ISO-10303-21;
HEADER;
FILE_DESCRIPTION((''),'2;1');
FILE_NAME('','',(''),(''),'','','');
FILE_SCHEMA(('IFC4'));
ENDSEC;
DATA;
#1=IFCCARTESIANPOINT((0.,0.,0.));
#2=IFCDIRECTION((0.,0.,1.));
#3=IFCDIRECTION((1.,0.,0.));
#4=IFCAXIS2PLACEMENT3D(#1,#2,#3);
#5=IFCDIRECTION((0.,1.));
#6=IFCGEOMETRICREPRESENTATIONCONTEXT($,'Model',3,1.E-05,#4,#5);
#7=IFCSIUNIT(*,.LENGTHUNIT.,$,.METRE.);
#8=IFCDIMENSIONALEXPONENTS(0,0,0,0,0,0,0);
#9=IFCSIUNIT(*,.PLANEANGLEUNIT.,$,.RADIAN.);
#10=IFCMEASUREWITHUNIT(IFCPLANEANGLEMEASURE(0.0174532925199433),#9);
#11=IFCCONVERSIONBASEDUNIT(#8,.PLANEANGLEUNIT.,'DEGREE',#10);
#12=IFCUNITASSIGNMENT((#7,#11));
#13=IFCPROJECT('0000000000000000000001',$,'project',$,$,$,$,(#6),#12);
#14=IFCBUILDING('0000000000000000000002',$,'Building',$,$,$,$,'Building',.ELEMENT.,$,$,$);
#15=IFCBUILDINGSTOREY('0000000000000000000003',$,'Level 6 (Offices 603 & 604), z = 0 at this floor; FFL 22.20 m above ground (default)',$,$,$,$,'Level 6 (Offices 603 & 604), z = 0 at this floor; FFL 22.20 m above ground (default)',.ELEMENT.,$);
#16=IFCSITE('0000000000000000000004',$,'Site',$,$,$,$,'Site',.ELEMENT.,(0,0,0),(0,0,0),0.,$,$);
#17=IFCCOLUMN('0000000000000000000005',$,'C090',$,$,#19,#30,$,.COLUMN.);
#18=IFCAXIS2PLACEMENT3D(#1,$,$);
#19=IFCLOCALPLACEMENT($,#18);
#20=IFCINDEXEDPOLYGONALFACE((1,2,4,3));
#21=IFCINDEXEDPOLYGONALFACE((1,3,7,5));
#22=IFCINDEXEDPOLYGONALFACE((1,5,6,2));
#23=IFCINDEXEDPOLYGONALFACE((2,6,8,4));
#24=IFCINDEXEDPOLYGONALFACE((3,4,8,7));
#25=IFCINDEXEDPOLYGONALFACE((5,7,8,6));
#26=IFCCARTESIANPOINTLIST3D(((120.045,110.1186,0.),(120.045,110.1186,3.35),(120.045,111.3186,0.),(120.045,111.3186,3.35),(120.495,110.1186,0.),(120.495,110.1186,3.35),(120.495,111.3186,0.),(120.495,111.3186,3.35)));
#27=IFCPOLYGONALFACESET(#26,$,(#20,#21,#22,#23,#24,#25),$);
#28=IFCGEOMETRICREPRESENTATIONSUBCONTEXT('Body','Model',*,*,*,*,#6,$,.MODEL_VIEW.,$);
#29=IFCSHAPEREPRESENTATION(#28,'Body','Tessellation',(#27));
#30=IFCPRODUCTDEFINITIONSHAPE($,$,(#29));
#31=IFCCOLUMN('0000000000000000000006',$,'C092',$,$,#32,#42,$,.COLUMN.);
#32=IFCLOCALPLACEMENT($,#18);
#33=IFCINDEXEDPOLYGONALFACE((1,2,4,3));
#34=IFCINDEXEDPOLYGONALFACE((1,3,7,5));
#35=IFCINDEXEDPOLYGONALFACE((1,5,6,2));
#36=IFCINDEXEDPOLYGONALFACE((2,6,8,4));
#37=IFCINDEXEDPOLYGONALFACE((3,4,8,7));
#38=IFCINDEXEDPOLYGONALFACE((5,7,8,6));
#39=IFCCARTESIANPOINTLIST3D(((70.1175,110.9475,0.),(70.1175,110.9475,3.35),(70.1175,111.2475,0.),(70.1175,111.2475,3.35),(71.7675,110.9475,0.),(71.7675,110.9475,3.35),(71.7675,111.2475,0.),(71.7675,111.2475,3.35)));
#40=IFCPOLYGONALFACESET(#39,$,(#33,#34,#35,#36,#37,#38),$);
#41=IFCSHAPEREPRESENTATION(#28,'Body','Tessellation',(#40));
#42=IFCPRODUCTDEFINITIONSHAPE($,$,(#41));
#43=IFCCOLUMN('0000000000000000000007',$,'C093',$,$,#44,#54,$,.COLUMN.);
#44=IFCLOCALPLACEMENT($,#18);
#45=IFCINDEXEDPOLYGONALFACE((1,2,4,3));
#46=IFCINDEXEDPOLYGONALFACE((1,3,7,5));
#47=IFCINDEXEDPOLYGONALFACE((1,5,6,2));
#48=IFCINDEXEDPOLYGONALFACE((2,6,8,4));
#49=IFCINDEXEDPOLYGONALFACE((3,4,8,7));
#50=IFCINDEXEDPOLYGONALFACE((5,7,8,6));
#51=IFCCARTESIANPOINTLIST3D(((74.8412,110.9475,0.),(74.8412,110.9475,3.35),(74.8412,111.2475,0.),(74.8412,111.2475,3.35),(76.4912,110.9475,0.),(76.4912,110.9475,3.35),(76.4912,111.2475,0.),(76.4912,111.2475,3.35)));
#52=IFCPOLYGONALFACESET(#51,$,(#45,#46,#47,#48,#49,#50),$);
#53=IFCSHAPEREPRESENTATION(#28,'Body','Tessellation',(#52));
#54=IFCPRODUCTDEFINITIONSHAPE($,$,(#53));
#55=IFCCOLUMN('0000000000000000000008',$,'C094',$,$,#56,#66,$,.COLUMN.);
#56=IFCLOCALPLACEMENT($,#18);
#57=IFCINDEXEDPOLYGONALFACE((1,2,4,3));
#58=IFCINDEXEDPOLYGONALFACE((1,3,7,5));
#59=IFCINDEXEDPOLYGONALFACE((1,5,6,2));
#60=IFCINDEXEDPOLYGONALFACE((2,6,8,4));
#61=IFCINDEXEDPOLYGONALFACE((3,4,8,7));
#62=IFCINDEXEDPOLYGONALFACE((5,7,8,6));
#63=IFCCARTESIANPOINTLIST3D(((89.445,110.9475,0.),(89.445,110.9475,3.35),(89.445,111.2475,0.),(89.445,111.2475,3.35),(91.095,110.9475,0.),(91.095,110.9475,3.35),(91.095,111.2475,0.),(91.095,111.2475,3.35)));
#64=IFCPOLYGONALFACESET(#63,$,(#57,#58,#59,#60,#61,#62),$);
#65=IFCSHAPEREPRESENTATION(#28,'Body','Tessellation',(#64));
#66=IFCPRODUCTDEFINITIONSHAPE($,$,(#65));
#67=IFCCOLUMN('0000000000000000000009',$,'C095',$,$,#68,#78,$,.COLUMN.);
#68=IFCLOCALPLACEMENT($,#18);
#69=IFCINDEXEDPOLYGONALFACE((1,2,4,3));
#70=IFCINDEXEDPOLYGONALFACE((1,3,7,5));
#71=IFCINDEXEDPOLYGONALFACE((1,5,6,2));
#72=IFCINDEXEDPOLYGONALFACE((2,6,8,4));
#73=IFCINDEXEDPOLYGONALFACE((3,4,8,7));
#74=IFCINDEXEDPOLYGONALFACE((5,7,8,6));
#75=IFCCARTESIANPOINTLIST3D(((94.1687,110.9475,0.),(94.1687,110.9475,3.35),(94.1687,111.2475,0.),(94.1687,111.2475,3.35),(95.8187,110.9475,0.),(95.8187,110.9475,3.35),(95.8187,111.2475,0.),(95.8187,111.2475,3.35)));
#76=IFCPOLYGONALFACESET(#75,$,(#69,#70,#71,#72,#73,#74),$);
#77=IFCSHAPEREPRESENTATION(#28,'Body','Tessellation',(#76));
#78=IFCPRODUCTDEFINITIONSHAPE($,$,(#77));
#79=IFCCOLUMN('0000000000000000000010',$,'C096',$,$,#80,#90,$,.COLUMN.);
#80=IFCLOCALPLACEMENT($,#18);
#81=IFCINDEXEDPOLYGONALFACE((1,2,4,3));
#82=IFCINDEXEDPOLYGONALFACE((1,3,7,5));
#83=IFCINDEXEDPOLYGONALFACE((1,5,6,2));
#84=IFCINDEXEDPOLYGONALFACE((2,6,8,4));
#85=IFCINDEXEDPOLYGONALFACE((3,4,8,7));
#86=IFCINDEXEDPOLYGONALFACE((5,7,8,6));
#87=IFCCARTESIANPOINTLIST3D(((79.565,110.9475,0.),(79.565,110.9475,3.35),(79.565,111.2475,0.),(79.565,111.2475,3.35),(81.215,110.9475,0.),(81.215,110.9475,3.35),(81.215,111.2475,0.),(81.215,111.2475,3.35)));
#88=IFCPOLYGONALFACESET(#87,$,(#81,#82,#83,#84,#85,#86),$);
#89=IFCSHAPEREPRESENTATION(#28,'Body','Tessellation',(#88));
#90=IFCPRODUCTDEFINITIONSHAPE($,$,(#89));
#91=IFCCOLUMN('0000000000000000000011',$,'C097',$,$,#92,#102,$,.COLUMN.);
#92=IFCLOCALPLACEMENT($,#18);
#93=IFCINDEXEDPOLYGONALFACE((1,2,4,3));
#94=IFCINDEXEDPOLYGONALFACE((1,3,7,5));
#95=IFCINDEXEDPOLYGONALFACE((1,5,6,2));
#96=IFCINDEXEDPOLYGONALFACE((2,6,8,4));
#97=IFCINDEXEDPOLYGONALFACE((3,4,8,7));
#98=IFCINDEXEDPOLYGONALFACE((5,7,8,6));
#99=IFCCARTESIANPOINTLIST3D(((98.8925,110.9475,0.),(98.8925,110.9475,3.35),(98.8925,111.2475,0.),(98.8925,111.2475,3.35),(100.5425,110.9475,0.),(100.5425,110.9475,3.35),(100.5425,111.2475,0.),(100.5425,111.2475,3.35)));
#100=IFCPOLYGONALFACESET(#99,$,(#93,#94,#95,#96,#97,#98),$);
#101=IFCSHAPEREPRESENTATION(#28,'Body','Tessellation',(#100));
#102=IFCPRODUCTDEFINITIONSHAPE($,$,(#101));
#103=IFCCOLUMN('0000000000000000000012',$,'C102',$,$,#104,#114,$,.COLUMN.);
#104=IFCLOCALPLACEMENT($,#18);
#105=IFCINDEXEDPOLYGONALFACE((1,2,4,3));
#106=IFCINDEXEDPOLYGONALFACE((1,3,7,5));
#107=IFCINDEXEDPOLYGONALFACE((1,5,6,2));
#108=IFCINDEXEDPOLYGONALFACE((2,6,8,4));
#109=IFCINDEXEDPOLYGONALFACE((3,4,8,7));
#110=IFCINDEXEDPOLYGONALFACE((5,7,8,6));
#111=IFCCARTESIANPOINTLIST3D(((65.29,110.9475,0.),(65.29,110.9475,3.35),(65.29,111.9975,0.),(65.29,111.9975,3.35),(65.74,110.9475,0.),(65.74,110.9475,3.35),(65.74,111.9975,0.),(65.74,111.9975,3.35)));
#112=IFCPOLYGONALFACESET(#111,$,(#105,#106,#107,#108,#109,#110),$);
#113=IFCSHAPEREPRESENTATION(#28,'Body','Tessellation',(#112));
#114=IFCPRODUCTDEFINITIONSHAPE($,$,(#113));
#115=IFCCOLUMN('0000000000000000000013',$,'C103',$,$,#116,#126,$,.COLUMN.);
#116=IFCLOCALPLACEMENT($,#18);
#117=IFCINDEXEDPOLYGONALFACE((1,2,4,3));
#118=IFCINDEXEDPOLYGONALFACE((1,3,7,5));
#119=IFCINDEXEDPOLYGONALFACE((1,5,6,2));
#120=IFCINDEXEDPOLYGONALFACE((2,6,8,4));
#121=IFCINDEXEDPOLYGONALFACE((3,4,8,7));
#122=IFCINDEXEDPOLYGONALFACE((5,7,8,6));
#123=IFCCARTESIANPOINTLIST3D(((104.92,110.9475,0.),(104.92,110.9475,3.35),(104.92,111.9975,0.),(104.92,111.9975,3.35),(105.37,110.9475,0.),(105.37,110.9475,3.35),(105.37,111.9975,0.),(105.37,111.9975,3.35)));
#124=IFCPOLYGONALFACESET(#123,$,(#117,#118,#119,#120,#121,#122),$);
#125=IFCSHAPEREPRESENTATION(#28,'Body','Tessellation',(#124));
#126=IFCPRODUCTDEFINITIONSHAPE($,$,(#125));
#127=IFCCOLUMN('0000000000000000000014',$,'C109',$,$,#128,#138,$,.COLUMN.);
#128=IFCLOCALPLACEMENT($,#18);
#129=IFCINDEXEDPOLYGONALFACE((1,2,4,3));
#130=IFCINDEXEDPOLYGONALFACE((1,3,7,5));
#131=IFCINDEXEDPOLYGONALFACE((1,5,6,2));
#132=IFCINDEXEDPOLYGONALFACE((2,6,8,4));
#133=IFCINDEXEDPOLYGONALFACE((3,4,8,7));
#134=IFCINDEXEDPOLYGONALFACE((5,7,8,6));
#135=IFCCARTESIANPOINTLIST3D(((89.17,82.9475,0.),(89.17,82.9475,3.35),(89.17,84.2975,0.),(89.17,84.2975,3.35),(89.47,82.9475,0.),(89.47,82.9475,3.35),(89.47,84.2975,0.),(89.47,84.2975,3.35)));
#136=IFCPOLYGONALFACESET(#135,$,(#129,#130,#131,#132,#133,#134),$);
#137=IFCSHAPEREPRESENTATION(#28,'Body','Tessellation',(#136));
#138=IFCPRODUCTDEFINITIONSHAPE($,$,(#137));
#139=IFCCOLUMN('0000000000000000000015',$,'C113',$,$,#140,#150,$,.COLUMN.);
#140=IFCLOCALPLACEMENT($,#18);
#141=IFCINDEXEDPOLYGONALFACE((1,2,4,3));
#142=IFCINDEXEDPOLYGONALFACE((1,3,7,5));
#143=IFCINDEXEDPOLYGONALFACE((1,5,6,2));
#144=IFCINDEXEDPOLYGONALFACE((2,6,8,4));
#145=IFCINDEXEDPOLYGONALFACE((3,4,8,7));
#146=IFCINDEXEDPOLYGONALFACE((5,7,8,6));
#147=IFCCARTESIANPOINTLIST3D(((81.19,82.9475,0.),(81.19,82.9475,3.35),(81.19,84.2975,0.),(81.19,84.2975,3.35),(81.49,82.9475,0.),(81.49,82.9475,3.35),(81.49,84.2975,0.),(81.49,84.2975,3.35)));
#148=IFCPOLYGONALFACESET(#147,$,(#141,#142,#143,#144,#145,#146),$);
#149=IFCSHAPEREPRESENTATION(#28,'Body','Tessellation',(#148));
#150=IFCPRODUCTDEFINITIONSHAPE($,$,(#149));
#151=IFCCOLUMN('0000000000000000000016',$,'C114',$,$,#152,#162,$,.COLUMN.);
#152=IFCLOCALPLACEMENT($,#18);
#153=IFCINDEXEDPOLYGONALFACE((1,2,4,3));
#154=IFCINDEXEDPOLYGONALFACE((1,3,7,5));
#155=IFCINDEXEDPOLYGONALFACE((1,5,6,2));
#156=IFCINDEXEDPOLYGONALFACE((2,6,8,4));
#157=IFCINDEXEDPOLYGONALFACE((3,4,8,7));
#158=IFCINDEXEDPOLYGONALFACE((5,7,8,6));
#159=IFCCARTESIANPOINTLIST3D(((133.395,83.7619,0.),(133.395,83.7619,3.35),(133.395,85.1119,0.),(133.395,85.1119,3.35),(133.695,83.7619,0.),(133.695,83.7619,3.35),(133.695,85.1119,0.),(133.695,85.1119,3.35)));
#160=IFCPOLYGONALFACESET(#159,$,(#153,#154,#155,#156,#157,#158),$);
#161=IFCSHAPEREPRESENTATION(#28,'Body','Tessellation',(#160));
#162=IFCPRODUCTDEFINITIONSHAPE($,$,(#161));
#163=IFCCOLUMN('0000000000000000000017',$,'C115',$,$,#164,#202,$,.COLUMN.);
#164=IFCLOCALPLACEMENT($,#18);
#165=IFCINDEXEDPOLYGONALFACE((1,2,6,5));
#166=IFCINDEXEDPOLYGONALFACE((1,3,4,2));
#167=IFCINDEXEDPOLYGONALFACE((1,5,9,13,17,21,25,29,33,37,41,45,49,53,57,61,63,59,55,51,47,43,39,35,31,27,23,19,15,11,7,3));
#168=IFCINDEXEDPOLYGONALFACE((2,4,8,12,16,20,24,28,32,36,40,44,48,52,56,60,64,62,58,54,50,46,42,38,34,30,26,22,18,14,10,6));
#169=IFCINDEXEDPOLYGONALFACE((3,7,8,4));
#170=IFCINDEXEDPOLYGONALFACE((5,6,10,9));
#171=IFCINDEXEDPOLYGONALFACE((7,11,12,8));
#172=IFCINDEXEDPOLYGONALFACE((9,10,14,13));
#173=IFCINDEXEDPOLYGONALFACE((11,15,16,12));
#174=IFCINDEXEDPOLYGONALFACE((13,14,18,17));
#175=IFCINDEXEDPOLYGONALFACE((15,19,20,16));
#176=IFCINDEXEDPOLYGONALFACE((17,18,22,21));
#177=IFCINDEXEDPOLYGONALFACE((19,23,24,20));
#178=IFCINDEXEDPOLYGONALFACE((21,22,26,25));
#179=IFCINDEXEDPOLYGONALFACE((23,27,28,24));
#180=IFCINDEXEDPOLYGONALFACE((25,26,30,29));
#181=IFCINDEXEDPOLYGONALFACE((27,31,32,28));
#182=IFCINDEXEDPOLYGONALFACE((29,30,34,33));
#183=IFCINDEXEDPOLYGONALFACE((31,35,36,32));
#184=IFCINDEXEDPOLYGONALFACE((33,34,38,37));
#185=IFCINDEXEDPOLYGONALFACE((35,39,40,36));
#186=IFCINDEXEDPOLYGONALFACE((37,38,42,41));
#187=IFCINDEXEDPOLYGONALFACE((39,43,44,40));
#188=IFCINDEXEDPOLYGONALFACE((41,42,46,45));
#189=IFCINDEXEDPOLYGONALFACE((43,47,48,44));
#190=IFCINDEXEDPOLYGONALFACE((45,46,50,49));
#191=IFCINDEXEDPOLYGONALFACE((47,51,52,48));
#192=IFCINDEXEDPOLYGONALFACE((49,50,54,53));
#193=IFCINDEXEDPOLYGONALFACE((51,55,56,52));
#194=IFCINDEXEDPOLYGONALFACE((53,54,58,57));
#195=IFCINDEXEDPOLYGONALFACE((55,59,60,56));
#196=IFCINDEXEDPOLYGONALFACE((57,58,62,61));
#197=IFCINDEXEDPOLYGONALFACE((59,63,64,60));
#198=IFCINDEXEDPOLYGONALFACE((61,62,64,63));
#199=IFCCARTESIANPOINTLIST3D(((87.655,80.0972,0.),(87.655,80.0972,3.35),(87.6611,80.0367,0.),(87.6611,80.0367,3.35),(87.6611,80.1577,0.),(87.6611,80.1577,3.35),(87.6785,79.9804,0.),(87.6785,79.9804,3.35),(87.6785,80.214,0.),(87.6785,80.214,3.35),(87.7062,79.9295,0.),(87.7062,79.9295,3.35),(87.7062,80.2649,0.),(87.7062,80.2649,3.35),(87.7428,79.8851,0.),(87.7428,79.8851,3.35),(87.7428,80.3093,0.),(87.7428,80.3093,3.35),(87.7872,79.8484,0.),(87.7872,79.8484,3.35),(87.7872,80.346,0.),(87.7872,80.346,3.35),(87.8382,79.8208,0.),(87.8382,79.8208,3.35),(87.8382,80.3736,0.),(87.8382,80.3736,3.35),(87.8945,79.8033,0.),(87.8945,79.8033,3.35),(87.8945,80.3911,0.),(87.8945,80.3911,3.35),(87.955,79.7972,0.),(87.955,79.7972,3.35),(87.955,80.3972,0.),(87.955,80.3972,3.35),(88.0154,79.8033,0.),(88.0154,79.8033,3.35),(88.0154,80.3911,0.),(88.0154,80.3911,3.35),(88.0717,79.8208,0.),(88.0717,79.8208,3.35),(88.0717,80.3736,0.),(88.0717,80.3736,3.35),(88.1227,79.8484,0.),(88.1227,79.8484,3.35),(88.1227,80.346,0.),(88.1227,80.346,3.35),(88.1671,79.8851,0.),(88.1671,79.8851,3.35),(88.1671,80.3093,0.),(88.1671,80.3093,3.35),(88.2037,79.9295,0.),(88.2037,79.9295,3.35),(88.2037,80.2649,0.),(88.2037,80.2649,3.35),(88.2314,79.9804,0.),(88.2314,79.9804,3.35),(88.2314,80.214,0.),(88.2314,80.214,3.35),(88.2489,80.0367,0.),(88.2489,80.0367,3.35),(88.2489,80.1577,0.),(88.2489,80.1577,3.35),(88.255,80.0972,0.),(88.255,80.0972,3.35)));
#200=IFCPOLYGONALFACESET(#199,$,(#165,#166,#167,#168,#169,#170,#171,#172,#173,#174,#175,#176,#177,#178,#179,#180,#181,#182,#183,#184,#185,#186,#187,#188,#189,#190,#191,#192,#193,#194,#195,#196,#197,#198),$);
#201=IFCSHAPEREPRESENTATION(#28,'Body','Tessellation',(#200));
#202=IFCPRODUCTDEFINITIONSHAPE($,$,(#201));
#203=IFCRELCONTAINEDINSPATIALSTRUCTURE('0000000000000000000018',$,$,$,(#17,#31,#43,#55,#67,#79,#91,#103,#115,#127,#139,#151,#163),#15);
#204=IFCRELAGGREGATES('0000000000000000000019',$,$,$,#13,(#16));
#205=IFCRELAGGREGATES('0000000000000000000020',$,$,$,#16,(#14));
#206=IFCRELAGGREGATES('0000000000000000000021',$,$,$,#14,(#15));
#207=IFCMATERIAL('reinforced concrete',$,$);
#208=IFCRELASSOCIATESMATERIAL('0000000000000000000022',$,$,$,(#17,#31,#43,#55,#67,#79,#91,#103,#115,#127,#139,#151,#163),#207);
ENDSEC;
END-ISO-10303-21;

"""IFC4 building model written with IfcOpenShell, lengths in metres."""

from ifc_helpers import new_model, entity, si_unit, converted_unit, direction, frame, frame_2d, origin_with_axes, place, context, subcontext, project, spatial, polyline, rectangle, outline, extrude, material, element, save


model = new_model("IFC4")

# Units and contexts
model_context = context("Model", 3, precision=1e-05, world=origin_with_axes(), true_north=direction((0.0, 1.0)))
body_context = subcontext(model_context, "Body", "Model", "MODEL_VIEW")
ifc_project = project(units=[si_unit("LENGTHUNIT", "METRE"), converted_unit("PLANEANGLEUNIT", "DEGREE", entity("IfcPlaneAngleMeasure", 0.0174532925199433), si_unit("PLANEANGLEUNIT", "RADIAN"), dimensions=[0, 0, 0, 0, 0, 0, 0])], contexts=[model_context])

# Site, building, storey
site = spatial("IfcSite", under=ifc_project, Name="Site", LongName="Site", CompositionType="ELEMENT", RefLatitude=(0, 0, 0), RefLongitude=(0, 0, 0), RefElevation=0.0)
building = spatial("IfcBuilding", under=site, Name="Building", LongName="Building", CompositionType="ELEMENT")
storey = spatial("IfcBuildingStorey", under=building, Name="Level 6 (Offices 603 & 604), z = 0 at this floor; FFL 22.20 m above ground (default)", LongName="Level 6 (Offices 603 & 604), z = 0 at this floor; FFL 22.20 m above ground (default)", CompositionType="ELEMENT")

# Columns
ifc_material_1 = material(Name="reinforced concrete")
placement = place(None, origin_with_axes())
element("IfcColumn", 1, at=placement, inside=storey, material=ifc_material_1, Name="C090", PredefinedType="COLUMN", context=body_context, shape_type="SweptSolid", body=[
    extrude(rectangle(XDim=1.2, YDim=0.45, at=frame_2d((0.0, 0.0), x_axis=(0.0, 1.0))), frame((120.27, 110.7186, 0.0), z_axis=(0.0, 0.0, 1.0), x_axis=(1.0, 0.0, 0.0)), (0.0, 0.0, 1.0), 3.35),
])
element("IfcColumn", 2, at=placement, inside=storey, material=ifc_material_1, Name="C092", PredefinedType="COLUMN", context=body_context, shape_type="SweptSolid", body=[
    extrude(rectangle(XDim=0.3, YDim=1.65, at=frame_2d((0.0, 0.0), x_axis=(0.0, 1.0))), frame((70.9425, 111.0975, 0.0), z_axis=(0.0, 0.0, 1.0), x_axis=(1.0, 0.0, 0.0)), (0.0, 0.0, 1.0), 3.35),
])
element("IfcColumn", 3, at=placement, inside=storey, material=ifc_material_1, Name="C093", PredefinedType="COLUMN", context=body_context, shape_type="SweptSolid", body=[
    extrude(rectangle(XDim=0.3, YDim=1.65, at=frame_2d((0.0, 0.0), x_axis=(0.0, 1.0))), frame((75.6662, 111.0975, 0.0), z_axis=(0.0, 0.0, 1.0), x_axis=(1.0, 0.0, 0.0)), (0.0, 0.0, 1.0), 3.35),
])
element("IfcColumn", 4, at=placement, inside=storey, material=ifc_material_1, Name="C094", PredefinedType="COLUMN", context=body_context, shape_type="SweptSolid", body=[
    extrude(rectangle(XDim=0.3, YDim=1.65, at=frame_2d((0.0, 0.0), x_axis=(0.0, 1.0))), frame((90.27, 111.0975, 0.0), z_axis=(0.0, 0.0, 1.0), x_axis=(1.0, 0.0, 0.0)), (0.0, 0.0, 1.0), 3.35),
])
element("IfcColumn", 5, at=placement, inside=storey, material=ifc_material_1, Name="C095", PredefinedType="COLUMN", context=body_context, shape_type="SweptSolid", body=[
    extrude(rectangle(XDim=0.3, YDim=1.65, at=frame_2d((0.0, 0.0), x_axis=(0.0, 1.0))), frame((94.9937, 111.0975, 0.0), z_axis=(0.0, 0.0, 1.0), x_axis=(1.0, 0.0, 0.0)), (0.0, 0.0, 1.0), 3.35),
])
element("IfcColumn", 6, at=placement, inside=storey, material=ifc_material_1, Name="C096", PredefinedType="COLUMN", context=body_context, shape_type="SweptSolid", body=[
    extrude(rectangle(XDim=0.3, YDim=1.65, at=frame_2d((0.0, 0.0), x_axis=(0.0, 1.0))), frame((80.39, 111.0975, 0.0), z_axis=(0.0, 0.0, 1.0), x_axis=(1.0, 0.0, 0.0)), (0.0, 0.0, 1.0), 3.35),
])
element("IfcColumn", 7, at=placement, inside=storey, material=ifc_material_1, Name="C097", PredefinedType="COLUMN", context=body_context, shape_type="SweptSolid", body=[
    extrude(rectangle(XDim=0.3, YDim=1.65, at=frame_2d((0.0, 0.0), x_axis=(0.0, 1.0))), frame((99.7175, 111.0975, 0.0), z_axis=(0.0, 0.0, 1.0), x_axis=(1.0, 0.0, 0.0)), (0.0, 0.0, 1.0), 3.35),
])
element("IfcColumn", 8, at=placement, inside=storey, material=ifc_material_1, Name="C102", PredefinedType="COLUMN", context=body_context, shape_type="SweptSolid", body=[
    extrude(rectangle(XDim=0.45, YDim=1.05, at=frame_2d((0.0, 0.0), x_axis=(-1.0, 0.0))), frame((65.515, 111.4725, 0.0), z_axis=(0.0, 0.0, 1.0), x_axis=(1.0, 0.0, 0.0)), (0.0, 0.0, 1.0), 3.35),
])
element("IfcColumn", 9, at=placement, inside=storey, material=ifc_material_1, Name="C103", PredefinedType="COLUMN", context=body_context, shape_type="SweptSolid", body=[
    extrude(rectangle(XDim=0.45, YDim=1.05, at=frame_2d((0.0, 0.0), x_axis=(-1.0, 0.0))), frame((105.145, 111.4725, 0.0), z_axis=(0.0, 0.0, 1.0), x_axis=(1.0, 0.0, 0.0)), (0.0, 0.0, 1.0), 3.35),
])
element("IfcColumn", 10, at=placement, inside=storey, material=ifc_material_1, Name="C109", PredefinedType="COLUMN", context=body_context, shape_type="SweptSolid", body=[
    extrude(rectangle(XDim=1.35, YDim=0.3, at=frame_2d((0.0, 0.0), x_axis=(0.0, 1.0))), frame((89.32, 83.6225, 0.0), z_axis=(0.0, 0.0, 1.0), x_axis=(1.0, 0.0, 0.0)), (0.0, 0.0, 1.0), 3.35),
])
element("IfcColumn", 11, at=placement, inside=storey, material=ifc_material_1, Name="C113", PredefinedType="COLUMN", context=body_context, shape_type="SweptSolid", body=[
    extrude(rectangle(XDim=1.35, YDim=0.3, at=frame_2d((0.0, 0.0), x_axis=(0.0, 1.0))), frame((81.34, 83.6225, 0.0), z_axis=(0.0, 0.0, 1.0), x_axis=(1.0, 0.0, 0.0)), (0.0, 0.0, 1.0), 3.35),
])
element("IfcColumn", 12, at=placement, inside=storey, material=ifc_material_1, Name="C114", PredefinedType="COLUMN", context=body_context, shape_type="SweptSolid", body=[
    extrude(rectangle(XDim=1.35, YDim=0.3, at=frame_2d((0.0, 0.0), x_axis=(0.0, -1.0))), frame((133.545, 84.4369, 0.0), z_axis=(0.0, 0.0, 1.0), x_axis=(1.0, 0.0, 0.0)), (0.0, 0.0, 1.0), 3.35),
])
element("IfcColumn", 13, at=placement, inside=storey, material=ifc_material_1, Name="C115", PredefinedType="COLUMN", context=body_context, shape_type="SweptSolid", body=[
    extrude(outline(polyline([(0.3, 0.0), (0.2939, -0.0605), (0.2764, -0.1168), (0.2487, -0.1677), (0.2121, -0.2121), (0.1677, -0.2488), (0.1167, -0.2764), (0.0604, -0.2939), (0.0, -0.3), (-0.0605, -0.2939), (-0.1168, -0.2764), (-0.1678, -0.2488), (-0.2122, -0.2121), (-0.2488, -0.1677), (-0.2765, -0.1168), (-0.2939, -0.0605), (-0.3, 0.0), (-0.2939, 0.0605), (-0.2765, 0.1168), (-0.2488, 0.1677), (-0.2122, 0.2121), (-0.1678, 0.2488), (-0.1168, 0.2764), (-0.0605, 0.2939), (0.0, 0.3), (0.0604, 0.2939), (0.1167, 0.2764), (0.1677, 0.2488), (0.2121, 0.2121), (0.2487, 0.1677), (0.2764, 0.1168), (0.2939, 0.0605), (0.3, 0.0)])), frame((87.955, 80.0972, 0.0), z_axis=(0.0, 0.0, 1.0), x_axis=(1.0, 0.0, 0.0)), (0.0, 0.0, 1.0), 3.35),
])

save(model, "model.ifc")
